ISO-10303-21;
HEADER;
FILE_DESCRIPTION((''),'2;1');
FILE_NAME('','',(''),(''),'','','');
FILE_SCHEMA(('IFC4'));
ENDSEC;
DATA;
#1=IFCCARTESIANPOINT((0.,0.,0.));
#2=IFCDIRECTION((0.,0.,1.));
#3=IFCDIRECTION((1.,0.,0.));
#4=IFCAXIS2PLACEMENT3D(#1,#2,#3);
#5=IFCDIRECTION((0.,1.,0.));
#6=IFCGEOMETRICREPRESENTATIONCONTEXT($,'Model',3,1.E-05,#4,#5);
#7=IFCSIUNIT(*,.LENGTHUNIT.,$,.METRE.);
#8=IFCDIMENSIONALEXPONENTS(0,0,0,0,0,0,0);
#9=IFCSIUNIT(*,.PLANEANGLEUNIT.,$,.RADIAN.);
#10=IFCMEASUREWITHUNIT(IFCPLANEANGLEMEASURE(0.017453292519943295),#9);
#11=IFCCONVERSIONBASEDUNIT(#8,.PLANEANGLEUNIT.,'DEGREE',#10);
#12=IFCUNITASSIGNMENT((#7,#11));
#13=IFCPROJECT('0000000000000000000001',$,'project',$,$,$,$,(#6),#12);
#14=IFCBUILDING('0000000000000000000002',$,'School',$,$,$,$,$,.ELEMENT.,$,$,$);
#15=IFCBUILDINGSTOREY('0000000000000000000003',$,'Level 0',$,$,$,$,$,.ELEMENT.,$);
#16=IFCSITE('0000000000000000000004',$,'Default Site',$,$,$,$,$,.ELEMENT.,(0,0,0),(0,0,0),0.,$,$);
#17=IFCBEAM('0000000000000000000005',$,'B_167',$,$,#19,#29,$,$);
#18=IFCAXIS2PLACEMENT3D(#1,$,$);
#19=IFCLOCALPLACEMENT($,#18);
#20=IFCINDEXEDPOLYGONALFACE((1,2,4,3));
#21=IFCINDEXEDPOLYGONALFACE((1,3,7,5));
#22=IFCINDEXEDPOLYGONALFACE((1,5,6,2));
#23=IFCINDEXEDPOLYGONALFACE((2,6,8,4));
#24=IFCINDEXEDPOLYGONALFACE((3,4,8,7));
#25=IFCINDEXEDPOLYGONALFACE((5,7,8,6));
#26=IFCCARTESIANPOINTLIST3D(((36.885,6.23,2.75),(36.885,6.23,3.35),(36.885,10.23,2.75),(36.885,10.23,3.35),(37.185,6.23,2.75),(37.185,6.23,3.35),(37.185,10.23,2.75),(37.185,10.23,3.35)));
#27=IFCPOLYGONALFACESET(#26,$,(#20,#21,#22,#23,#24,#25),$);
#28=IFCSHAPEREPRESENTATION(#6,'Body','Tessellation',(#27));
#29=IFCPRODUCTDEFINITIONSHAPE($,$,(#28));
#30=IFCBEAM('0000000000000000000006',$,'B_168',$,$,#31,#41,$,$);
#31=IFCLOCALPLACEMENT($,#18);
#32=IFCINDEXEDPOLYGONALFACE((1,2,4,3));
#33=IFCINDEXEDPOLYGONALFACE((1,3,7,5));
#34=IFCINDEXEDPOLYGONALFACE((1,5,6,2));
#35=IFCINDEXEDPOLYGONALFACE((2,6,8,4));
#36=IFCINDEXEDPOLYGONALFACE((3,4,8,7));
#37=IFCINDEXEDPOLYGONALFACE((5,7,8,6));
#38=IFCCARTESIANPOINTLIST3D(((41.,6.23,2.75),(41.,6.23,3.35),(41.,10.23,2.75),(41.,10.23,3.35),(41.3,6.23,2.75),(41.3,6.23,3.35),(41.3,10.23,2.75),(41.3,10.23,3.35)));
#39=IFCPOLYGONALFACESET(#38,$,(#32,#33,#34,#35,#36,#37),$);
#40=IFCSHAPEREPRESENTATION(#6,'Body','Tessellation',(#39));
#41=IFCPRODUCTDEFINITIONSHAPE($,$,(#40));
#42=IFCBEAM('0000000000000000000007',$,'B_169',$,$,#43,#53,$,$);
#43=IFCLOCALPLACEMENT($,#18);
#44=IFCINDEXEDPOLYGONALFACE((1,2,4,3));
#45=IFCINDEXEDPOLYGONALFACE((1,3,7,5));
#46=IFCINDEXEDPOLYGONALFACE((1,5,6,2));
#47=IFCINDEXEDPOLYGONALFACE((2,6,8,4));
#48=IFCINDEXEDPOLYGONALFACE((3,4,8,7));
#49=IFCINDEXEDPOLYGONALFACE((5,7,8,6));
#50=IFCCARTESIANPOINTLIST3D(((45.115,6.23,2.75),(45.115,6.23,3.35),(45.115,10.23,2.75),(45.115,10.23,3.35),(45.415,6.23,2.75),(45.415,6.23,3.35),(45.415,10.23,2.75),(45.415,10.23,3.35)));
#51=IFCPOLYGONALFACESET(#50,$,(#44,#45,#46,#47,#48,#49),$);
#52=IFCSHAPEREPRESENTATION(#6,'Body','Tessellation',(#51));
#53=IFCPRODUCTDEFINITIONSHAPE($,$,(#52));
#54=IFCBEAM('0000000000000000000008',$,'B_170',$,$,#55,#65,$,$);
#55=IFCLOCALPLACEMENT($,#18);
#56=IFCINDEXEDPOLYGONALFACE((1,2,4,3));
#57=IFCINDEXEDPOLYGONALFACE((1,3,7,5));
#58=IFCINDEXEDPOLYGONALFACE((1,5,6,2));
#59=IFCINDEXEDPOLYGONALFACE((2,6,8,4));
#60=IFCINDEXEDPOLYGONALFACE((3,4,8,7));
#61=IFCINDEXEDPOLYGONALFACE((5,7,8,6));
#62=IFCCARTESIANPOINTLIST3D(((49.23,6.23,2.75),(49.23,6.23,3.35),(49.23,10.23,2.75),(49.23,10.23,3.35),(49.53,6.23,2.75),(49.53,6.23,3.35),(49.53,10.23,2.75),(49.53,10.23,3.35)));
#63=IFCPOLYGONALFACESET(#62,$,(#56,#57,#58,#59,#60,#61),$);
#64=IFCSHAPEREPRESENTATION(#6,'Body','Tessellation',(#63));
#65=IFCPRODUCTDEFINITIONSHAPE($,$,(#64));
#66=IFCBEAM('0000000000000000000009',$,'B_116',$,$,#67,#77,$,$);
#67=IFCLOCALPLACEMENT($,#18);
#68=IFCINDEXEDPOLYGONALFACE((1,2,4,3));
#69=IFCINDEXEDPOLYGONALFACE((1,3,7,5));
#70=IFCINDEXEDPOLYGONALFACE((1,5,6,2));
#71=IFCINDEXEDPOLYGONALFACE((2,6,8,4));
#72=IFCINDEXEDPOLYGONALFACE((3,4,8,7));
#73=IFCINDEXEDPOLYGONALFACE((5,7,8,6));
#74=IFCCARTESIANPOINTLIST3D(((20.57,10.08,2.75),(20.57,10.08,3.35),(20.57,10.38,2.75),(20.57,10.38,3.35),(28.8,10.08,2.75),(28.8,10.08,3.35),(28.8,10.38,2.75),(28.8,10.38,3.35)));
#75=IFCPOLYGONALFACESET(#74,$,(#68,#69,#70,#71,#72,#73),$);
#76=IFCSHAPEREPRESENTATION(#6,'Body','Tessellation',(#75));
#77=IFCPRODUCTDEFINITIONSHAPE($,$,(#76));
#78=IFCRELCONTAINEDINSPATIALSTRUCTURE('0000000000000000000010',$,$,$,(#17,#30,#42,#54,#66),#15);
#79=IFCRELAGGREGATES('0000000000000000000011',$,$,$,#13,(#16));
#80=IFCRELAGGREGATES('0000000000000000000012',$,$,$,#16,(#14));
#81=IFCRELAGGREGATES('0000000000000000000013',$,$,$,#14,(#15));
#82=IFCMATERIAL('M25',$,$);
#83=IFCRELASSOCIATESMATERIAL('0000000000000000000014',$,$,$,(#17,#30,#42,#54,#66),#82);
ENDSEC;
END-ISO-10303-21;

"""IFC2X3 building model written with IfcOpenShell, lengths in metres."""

from ifc_helpers import new_model, entity, si_unit, converted_unit, direction, frame, frame_2d, origin_with_axes, place, context, project, spatial, rectangle, extrude, material, element, save


model = new_model("IFC2X3")

# Units and contexts
model_context = context("Model", 3, precision=1e-05, world=origin_with_axes(), true_north=direction((0.0, 1.0, 0.0)))
ifc_project = project(units=[si_unit("LENGTHUNIT", "METRE"), converted_unit("PLANEANGLEUNIT", "DEGREE", entity("IfcPlaneAngleMeasure", 0.017453292519943295), si_unit("PLANEANGLEUNIT", "RADIAN"), dimensions=[0, 0, 0, 0, 0, 0, 0])], contexts=[model_context])

# Site, building, storey
site = spatial("IfcSite", under=ifc_project, Name="Default Site", CompositionType="ELEMENT", RefLatitude=(0, 0, 0), RefLongitude=(0, 0, 0), RefElevation=0.0)
building = spatial("IfcBuilding", under=site, Name="School", CompositionType="ELEMENT")
storey = spatial("IfcBuildingStorey", under=building, Name="Level 0", CompositionType="ELEMENT")

# Shared definitions
ifc_material = material(Name="M25")
placement = place(None, origin_with_axes())

# Beams
element("IfcBeam", 1, at=placement, inside=storey, material=ifc_material, Name="B_167", context=model_context, shape_type="SweptSolid", body=[
    extrude(rectangle(XDim=0.3, YDim=0.6, at=frame_2d((0.0, 0.0), x_axis=(0.0, 1.0, 0.0))), frame((37.035, 6.23, 3.05), z_axis=(0.0, 1.0, 0.0), x_axis=(0.0, 0.0, -1.0)), (0.0, 0.0, 1.0), 4.0),
])
element("IfcBeam", 2, at=placement, inside=storey, material=ifc_material, Name="B_168", context=model_context, shape_type="SweptSolid", body=[
    extrude(rectangle(XDim=0.3, YDim=0.6, at=frame_2d((0.0, 0.0), x_axis=(0.0, 1.0, 0.0))), frame((41.15, 6.23, 3.05), z_axis=(0.0, 1.0, 0.0), x_axis=(0.0, 0.0, -1.0)), (0.0, 0.0, 1.0), 4.0),
])
element("IfcBeam", 3, at=placement, inside=storey, material=ifc_material, Name="B_169", context=model_context, shape_type="SweptSolid", body=[
    extrude(rectangle(XDim=0.3, YDim=0.6, at=frame_2d((0.0, 0.0), x_axis=(0.0, 1.0, 0.0))), frame((45.265, 6.23, 3.05), z_axis=(0.0, 1.0, 0.0), x_axis=(0.0, 0.0, -1.0)), (0.0, 0.0, 1.0), 4.0),
])
element("IfcBeam", 4, at=placement, inside=storey, material=ifc_material, Name="B_170", context=model_context, shape_type="SweptSolid", body=[
    extrude(rectangle(XDim=0.3, YDim=0.6, at=frame_2d((0.0, 0.0), x_axis=(0.0, 1.0, 0.0))), frame((49.38, 6.23, 3.05), z_axis=(0.0, 1.0, 0.0), x_axis=(0.0, 0.0, -1.0)), (0.0, 0.0, 1.0), 4.0),
])
element("IfcBeam", 5, at=placement, inside=storey, material=ifc_material, Name="B_116", context=model_context, shape_type="SweptSolid", body=[
    extrude(rectangle(XDim=0.3, YDim=0.6, at=frame_2d((0.0, 0.0), x_axis=(0.0, 1.0, 0.0))), frame((20.57, 10.23, 3.05), z_axis=(1.0, 0.0, 0.0), x_axis=(0.0, 0.0, -1.0)), (0.0, 0.0, 1.0), 8.23),
])

save(model, "model.ifc")
